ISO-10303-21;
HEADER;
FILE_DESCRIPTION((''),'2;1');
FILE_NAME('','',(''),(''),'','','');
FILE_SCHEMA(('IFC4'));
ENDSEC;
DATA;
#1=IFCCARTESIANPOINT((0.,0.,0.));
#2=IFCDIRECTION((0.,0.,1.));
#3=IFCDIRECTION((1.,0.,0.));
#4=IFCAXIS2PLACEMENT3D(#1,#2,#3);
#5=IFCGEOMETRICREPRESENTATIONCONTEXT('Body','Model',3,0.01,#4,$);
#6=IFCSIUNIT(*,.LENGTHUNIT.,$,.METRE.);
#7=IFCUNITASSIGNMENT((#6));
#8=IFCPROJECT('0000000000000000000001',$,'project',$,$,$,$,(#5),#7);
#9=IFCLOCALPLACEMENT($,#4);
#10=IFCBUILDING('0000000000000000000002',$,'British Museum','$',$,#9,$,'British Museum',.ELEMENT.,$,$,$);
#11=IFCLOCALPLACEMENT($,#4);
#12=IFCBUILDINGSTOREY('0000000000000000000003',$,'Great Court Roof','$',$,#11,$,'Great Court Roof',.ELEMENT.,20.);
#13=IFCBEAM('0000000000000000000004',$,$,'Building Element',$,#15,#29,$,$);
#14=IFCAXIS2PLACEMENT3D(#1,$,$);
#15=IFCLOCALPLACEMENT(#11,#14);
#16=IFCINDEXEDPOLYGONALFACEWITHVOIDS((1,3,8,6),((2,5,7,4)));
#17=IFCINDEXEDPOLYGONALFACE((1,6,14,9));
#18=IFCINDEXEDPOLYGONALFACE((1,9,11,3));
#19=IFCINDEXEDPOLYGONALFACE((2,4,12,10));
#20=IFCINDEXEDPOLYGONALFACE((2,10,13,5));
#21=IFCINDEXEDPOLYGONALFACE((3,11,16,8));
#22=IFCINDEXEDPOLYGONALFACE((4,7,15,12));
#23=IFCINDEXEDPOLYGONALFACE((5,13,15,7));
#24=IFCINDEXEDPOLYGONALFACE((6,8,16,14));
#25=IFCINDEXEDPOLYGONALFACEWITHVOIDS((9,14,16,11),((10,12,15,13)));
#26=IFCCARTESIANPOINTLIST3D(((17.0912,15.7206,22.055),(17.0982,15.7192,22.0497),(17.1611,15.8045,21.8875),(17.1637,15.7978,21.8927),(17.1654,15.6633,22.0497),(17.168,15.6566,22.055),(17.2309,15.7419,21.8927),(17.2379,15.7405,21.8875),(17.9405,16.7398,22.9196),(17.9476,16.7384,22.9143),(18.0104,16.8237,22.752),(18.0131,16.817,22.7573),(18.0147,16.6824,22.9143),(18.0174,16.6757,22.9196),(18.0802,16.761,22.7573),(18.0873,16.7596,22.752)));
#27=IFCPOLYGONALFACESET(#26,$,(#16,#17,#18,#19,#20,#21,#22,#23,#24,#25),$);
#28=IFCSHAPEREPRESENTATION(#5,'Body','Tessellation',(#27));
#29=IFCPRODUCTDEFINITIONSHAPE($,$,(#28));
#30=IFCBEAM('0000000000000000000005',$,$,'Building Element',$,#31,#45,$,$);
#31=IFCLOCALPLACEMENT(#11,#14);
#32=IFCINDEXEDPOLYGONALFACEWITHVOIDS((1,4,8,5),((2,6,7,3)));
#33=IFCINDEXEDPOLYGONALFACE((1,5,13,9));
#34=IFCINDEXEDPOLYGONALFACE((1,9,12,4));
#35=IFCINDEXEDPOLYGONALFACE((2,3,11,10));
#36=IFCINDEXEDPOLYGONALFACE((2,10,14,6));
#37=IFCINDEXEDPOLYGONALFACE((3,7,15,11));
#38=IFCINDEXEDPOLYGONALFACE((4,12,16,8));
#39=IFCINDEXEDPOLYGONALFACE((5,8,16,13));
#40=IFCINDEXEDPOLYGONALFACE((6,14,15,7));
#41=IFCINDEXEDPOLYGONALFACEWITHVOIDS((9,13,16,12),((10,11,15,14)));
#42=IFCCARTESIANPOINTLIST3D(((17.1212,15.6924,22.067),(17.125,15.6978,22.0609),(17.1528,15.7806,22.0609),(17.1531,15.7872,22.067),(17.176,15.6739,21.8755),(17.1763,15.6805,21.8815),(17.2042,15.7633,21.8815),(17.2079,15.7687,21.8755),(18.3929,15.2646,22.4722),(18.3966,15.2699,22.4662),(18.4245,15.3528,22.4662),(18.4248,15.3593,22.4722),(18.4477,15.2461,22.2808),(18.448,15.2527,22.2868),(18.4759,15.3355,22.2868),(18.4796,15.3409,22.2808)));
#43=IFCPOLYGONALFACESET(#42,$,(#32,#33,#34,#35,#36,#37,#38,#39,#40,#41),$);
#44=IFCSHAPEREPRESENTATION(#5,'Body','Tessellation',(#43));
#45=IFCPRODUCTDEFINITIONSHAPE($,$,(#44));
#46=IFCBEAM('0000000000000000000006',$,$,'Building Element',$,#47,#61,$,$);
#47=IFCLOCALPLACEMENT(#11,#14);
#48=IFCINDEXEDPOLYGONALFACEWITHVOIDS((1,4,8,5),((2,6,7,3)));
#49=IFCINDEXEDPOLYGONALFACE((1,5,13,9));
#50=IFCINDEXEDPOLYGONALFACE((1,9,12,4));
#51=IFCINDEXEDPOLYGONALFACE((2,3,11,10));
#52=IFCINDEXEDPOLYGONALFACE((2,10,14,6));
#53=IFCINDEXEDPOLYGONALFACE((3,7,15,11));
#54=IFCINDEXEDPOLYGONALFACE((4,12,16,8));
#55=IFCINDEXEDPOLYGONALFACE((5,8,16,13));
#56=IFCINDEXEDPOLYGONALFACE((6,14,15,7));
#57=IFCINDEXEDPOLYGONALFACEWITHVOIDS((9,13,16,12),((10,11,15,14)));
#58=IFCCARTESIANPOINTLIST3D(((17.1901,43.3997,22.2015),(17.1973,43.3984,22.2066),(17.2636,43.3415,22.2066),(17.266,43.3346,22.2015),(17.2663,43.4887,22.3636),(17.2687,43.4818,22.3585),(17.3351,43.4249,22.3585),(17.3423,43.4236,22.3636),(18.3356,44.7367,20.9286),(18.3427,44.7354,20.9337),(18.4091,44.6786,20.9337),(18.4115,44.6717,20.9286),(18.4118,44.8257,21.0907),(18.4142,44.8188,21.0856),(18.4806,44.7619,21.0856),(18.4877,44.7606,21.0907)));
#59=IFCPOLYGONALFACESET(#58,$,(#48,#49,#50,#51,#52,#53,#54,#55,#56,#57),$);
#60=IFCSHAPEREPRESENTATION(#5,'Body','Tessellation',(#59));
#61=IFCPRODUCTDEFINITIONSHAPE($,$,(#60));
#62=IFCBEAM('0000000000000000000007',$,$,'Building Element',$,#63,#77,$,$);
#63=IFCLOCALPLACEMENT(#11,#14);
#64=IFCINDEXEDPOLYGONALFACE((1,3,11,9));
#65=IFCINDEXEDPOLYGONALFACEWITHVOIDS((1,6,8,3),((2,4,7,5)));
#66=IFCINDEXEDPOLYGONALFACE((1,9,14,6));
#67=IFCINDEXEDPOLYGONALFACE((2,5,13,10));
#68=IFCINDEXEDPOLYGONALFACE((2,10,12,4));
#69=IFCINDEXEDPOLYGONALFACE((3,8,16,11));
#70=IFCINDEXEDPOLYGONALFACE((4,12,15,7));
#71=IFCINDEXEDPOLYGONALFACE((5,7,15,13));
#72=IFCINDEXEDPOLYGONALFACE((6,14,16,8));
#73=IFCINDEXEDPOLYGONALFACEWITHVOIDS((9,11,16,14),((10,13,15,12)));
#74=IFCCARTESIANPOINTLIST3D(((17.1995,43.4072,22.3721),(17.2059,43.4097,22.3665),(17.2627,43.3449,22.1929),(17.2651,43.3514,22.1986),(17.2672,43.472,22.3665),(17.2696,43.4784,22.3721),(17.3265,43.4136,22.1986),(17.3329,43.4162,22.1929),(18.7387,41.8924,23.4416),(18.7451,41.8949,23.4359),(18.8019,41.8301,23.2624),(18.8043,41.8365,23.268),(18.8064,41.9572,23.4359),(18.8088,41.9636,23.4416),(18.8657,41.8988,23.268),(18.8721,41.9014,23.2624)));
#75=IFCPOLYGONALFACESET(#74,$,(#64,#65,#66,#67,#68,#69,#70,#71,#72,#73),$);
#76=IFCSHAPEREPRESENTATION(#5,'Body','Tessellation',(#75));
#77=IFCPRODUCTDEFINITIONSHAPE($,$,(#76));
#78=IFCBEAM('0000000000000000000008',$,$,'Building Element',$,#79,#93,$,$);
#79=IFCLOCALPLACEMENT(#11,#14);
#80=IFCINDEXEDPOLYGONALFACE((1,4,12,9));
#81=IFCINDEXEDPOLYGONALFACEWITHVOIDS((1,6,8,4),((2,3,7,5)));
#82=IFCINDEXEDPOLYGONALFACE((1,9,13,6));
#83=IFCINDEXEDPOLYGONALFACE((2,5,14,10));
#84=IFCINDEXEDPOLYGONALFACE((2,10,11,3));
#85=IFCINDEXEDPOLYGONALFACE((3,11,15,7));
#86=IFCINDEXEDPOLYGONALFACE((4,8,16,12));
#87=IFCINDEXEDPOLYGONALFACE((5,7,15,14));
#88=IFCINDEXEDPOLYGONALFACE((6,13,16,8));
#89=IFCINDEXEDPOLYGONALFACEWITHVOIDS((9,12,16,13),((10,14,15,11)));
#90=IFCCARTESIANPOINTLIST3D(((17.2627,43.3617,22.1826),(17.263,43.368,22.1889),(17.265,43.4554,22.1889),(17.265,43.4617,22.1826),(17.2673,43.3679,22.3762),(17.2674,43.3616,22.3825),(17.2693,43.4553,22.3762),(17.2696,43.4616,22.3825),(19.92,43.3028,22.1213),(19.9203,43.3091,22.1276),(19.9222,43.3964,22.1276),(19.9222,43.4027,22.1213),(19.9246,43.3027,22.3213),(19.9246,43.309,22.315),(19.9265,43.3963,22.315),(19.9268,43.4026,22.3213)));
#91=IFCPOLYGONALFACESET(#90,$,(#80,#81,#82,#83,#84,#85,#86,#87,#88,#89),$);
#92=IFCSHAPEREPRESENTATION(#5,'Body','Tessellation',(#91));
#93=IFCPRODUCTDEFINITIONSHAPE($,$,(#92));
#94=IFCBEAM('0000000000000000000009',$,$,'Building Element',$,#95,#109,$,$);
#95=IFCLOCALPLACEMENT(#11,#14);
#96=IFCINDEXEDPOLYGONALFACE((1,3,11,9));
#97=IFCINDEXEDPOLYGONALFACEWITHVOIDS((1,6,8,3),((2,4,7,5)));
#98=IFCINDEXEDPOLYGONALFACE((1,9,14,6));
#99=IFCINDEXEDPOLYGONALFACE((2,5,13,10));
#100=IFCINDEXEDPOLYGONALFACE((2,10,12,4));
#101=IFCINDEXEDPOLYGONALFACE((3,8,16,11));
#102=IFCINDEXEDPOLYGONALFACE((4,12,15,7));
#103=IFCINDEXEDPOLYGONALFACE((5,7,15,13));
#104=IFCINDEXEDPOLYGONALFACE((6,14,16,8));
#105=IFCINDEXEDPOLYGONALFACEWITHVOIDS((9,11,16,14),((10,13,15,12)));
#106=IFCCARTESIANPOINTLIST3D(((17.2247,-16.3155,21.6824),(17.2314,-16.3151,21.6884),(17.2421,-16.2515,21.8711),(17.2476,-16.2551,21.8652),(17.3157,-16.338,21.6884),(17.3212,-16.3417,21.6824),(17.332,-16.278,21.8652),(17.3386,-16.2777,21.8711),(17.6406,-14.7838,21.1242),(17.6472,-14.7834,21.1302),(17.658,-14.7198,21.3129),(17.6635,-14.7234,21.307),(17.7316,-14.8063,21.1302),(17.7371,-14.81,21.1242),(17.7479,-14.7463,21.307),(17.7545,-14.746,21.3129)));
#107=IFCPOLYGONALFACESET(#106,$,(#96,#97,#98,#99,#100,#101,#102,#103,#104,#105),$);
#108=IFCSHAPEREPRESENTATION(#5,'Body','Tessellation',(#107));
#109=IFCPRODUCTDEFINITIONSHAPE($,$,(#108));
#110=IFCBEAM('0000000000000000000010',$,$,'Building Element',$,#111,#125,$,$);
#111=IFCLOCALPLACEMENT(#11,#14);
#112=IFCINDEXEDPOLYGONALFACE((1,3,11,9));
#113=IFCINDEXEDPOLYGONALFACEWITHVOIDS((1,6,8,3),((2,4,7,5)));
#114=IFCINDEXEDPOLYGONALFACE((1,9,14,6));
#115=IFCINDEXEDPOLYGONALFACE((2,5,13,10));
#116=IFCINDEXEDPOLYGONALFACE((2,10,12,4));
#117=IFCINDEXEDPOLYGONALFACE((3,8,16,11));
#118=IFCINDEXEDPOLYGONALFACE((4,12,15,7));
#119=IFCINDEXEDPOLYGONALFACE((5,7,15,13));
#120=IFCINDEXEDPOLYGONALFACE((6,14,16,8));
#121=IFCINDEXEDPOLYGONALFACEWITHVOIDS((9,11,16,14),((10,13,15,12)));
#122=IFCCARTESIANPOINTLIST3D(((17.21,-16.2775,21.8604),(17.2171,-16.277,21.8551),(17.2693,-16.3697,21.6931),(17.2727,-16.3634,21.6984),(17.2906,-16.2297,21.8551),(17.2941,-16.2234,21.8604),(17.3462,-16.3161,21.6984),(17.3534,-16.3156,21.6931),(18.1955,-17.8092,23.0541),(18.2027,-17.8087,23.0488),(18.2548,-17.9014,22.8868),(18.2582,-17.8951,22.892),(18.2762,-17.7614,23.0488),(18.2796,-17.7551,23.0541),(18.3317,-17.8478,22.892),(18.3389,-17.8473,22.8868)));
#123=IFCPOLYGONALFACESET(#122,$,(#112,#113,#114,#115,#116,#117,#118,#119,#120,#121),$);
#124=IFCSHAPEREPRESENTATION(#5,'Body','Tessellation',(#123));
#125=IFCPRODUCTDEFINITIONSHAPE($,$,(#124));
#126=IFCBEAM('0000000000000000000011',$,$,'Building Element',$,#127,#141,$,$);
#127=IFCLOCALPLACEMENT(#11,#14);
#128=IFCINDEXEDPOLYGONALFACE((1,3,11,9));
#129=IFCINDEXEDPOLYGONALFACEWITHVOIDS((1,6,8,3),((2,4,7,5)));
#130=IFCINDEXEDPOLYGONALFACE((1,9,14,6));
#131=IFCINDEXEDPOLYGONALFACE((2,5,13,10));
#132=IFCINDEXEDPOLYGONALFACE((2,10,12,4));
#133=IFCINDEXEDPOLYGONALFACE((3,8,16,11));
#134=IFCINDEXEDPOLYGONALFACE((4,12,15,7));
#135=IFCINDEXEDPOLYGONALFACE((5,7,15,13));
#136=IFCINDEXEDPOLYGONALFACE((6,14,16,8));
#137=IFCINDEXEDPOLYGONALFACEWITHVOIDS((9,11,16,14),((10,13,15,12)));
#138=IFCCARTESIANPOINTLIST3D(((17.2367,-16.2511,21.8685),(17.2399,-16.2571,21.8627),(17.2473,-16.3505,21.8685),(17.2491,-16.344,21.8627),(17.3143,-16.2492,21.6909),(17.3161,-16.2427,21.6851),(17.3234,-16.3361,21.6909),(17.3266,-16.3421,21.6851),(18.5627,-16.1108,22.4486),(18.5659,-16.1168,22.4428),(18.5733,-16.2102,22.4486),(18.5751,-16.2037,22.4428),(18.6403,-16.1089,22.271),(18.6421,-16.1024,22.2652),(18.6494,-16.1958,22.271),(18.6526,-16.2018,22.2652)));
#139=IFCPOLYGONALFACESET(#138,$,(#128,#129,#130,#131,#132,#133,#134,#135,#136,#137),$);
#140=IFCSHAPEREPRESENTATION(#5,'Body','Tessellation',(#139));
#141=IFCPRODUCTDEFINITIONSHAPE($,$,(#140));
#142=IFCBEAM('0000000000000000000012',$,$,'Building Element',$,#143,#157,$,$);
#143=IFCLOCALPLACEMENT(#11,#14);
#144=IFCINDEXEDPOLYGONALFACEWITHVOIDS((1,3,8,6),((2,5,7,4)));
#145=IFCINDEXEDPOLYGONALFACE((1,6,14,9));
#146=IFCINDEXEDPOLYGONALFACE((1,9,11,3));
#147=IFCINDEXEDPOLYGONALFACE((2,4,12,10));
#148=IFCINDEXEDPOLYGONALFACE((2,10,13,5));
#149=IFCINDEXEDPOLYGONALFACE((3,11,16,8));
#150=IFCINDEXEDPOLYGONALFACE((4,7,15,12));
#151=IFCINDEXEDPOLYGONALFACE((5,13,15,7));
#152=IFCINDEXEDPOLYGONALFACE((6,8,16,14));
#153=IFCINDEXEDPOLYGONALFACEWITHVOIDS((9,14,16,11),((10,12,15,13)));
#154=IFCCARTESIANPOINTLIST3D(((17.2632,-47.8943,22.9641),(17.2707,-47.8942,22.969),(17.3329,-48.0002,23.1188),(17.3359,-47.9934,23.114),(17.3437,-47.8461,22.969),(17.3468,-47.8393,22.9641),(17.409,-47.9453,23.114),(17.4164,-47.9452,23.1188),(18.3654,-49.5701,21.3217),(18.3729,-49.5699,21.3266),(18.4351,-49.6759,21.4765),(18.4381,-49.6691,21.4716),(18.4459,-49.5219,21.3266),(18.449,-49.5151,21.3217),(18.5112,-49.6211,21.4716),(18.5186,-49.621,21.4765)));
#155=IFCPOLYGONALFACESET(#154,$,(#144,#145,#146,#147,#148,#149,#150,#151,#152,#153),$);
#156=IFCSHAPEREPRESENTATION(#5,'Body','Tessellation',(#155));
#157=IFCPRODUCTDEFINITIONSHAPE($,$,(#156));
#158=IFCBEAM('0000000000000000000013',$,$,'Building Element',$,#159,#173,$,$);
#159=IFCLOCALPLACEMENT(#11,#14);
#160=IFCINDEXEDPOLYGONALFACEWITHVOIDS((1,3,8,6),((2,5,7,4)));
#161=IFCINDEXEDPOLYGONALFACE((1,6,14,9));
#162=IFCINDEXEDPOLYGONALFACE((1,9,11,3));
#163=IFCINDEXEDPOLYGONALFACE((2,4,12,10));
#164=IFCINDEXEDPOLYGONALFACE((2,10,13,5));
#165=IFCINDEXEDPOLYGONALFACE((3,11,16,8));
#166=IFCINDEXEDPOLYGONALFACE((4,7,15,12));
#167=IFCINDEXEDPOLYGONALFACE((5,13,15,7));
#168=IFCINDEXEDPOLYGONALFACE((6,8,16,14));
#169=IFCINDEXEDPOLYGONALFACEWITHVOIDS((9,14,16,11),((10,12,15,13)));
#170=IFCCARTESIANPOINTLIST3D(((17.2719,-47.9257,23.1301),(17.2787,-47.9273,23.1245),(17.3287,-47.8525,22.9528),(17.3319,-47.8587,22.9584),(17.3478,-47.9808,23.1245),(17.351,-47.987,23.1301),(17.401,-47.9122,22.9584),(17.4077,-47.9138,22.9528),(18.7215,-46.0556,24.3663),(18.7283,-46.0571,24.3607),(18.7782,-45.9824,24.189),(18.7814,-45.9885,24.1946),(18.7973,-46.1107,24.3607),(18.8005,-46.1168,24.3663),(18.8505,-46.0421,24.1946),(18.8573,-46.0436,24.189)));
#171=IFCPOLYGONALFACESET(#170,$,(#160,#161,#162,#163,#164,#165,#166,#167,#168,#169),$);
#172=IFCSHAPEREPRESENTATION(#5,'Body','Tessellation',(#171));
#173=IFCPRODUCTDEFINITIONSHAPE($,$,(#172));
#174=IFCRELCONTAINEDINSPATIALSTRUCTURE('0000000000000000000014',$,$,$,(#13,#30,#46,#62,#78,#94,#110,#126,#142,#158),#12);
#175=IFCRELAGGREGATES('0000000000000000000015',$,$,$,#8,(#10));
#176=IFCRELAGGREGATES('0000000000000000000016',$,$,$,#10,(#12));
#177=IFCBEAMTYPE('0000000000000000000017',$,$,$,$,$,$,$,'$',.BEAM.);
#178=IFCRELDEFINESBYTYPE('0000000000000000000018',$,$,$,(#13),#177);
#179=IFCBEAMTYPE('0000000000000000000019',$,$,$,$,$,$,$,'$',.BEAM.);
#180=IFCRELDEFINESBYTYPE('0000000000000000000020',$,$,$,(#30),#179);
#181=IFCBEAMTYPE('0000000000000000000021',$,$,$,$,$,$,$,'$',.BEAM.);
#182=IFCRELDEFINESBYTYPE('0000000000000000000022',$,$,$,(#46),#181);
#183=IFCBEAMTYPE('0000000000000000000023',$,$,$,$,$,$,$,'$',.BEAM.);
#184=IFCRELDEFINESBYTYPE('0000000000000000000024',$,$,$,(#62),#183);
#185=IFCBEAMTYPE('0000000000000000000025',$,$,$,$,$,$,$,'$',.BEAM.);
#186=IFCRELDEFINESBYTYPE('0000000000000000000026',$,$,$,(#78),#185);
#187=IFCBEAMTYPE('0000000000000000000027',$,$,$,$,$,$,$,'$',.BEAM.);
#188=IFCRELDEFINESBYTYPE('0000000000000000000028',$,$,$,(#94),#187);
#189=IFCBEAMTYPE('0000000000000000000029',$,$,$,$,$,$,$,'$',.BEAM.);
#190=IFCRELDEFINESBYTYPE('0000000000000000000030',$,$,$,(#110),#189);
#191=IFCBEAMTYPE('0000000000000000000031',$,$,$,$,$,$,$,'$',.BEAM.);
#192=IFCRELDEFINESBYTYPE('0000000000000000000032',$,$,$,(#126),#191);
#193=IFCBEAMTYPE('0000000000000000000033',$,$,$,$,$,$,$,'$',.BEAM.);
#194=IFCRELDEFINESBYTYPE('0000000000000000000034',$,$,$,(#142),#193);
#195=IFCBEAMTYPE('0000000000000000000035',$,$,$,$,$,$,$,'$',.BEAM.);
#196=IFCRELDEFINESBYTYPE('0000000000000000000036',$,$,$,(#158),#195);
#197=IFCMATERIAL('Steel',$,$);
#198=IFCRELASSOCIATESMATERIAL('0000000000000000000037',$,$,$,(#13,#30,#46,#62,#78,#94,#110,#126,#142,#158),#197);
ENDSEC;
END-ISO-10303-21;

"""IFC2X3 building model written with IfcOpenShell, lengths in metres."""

from ifc_helpers import new_model, si_unit, frame, origin_with_axes, origin_2d, place, context, project, spatial, hollow_rectangle, extrude, material, type_object, element, save


model = new_model("IFC2X3")

# Units and contexts
model_context = context("Model", 3, precision=0.01, world=origin_with_axes(), identifier="Body")
ifc_project = project(units=[si_unit("LENGTHUNIT", "METRE")], contexts=[model_context])

# Building, storey
building_placement = place(None, origin_with_axes())
building = spatial("IfcBuilding", under=ifc_project, at=building_placement, Name="British Museum", Description="$", LongName="British Museum", CompositionType="ELEMENT")
storey_placement = place(None, origin_with_axes())
storey = spatial("IfcBuildingStorey", under=building, at=storey_placement, Name="Great Court Roof", Description="$", LongName="Great Court Roof", CompositionType="ELEMENT", Elevation=20.0)

# Beams
ifc_material = material(Name="Steel")
beam_type_1 = type_object("IfcBeamType", ElementType="$", PredefinedType="BEAM")
beam_1_placement = place(None, origin_with_axes())
element("IfcBeam", 1, at=beam_1_placement, inside=storey, type_object=beam_type_1, material=ifc_material, Description="Building Element", context=model_context, shape_type="SweptSolid", body=[
    extrude(hollow_rectangle(XDim=0.1, YDim=0.2, WallThickness=0.0063, InnerFilletRadius=0.0, OuterFilletRadius=0.0, at=origin_2d()), frame((17.1646, 15.7306, 21.9712), z_axis=(0.536356, 0.643597, 0.54599), x_axis=(-0.768206, 0.640203, 0.0)), (0.0, 0.0, 1.0), 1.5835),
])
beam_type_2 = type_object("IfcBeamType", ElementType="$", PredefinedType="BEAM")
beam_2_placement = place(None, origin_with_axes())
element("IfcBeam", 2, at=beam_2_placement, inside=storey, type_object=beam_type_2, material=ifc_material, Description="Building Element", context=model_context, shape_type="SweptSolid", body=[
    extrude(hollow_rectangle(XDim=0.1, YDim=0.2, WallThickness=0.0063, InnerFilletRadius=0.0, OuterFilletRadius=0.0, at=origin_2d()), frame((17.1646, 15.7306, 21.9712), z_axis=(0.907317, -0.30525, 0.289135), x_axis=(0.318869, 0.947799, 0.0)), (0.0, 0.0, 1.0), 1.4016),
])
beam_type_3 = type_object("IfcBeamType", ElementType="$", PredefinedType="BEAM")
beam_3_placement = place(None, origin_with_axes())
element("IfcBeam", 3, at=beam_3_placement, inside=storey, type_object=beam_type_3, material=ifc_material, Description="Building Element", context=model_context, shape_type="SweptSolid", body=[
    extrude(hollow_rectangle(XDim=0.1, YDim=0.2, WallThickness=0.0063, InnerFilletRadius=0.0, OuterFilletRadius=0.0, at=origin_2d()), frame((17.2662, 43.4117, 22.2825), z_axis=(0.527257, 0.615413, -0.58589), x_axis=(-0.759403, 0.650621, 0.0)), (0.0, 0.0, 1.0), 2.1725),
])
beam_type_4 = type_object("IfcBeamType", ElementType="$", PredefinedType="BEAM")
beam_4_placement = place(None, origin_with_axes())
element("IfcBeam", 4, at=beam_4_placement, inside=storey, type_object=beam_type_4, material=ifc_material, Description="Building Element", context=model_context, shape_type="SweptSolid", body=[
    extrude(hollow_rectangle(XDim=0.1, YDim=0.2, WallThickness=0.0063, InnerFilletRadius=0.0, OuterFilletRadius=0.0, at=origin_2d()), frame((17.2662, 43.4117, 22.2825), z_axis=(0.638706, -0.628582, 0.443778), x_axis=(0.701435, 0.712733, 0.0)), (0.0, 0.0, 1.0), 2.4099),
])
beam_type_5 = type_object("IfcBeamType", ElementType="$", PredefinedType="BEAM")
beam_5_placement = place(None, origin_with_axes())
element("IfcBeam", 5, at=beam_5_placement, inside=storey, type_object=beam_type_5, material=ifc_material, Description="Building Element", context=model_context, shape_type="SweptSolid", body=[
    extrude(hollow_rectangle(XDim=0.1, YDim=0.2, WallThickness=0.0063, InnerFilletRadius=0.0, OuterFilletRadius=0.0, at=origin_2d()), frame((17.2662, 43.4117, 22.2825), z_axis=(0.999489, -0.022179, -0.023032), x_axis=(0.022185, 0.999754, 0.0)), (0.0, 0.0, 1.0), 2.6586),
])
beam_type_6 = type_object("IfcBeamType", ElementType="$", PredefinedType="BEAM")
beam_6_placement = place(None, origin_with_axes())
element("IfcBeam", 6, at=beam_6_placement, inside=storey, type_object=beam_type_6, material=ifc_material, Description="Building Element", context=model_context, shape_type="SweptSolid", body=[
    extrude(hollow_rectangle(XDim=0.1, YDim=0.2, WallThickness=0.0063, InnerFilletRadius=0.0, OuterFilletRadius=0.0, at=origin_2d()), frame((17.2817, -16.2966, 21.7768), z_axis=(0.247187, 0.910395, -0.331782), x_axis=(-0.96506, 0.262029, 0.0)), (0.0, 0.0, 1.0), 1.6824),
])
beam_type_7 = type_object("IfcBeamType", ElementType="$", PredefinedType="BEAM")
beam_7_placement = place(None, origin_with_axes())
element("IfcBeam", 7, at=beam_7_placement, inside=storey, type_object=beam_type_7, material=ifc_material, Description="Building Element", context=model_context, shape_type="SweptSolid", body=[
    extrude(hollow_rectangle(XDim=0.1, YDim=0.2, WallThickness=0.0063, InnerFilletRadius=0.0, OuterFilletRadius=0.0, at=origin_2d()), frame((17.2817, -16.2966, 21.7768), z_axis=(0.45257, -0.703361, 0.548145), x_axis=(0.840956, 0.541104, 0.0)), (0.0, 0.0, 1.0), 2.1776),
])
beam_type_8 = type_object("IfcBeamType", ElementType="$", PredefinedType="BEAM")
beam_8_placement = place(None, origin_with_axes())
element("IfcBeam", 8, at=beam_8_placement, inside=storey, type_object=beam_type_8, material=ifc_material, Description="Building Element", context=model_context, shape_type="SweptSolid", body=[
    extrude(hollow_rectangle(XDim=0.1, YDim=0.2, WallThickness=0.0063, InnerFilletRadius=0.0, OuterFilletRadius=0.0, at=origin_2d()), frame((17.2817, -16.2966, 21.7768), z_axis=(0.911876, 0.096474, 0.398968), x_axis=(-0.10521, 0.99445, 0.0)), (0.0, 0.0, 1.0), 1.4541),
])
beam_type_9 = type_object("IfcBeamType", ElementType="$", PredefinedType="BEAM")
beam_9_placement = place(None, origin_with_axes())
element("IfcBeam", 9, at=beam_9_placement, inside=storey, type_object=beam_type_9, material=ifc_material, Description="Building Element", context=model_context, shape_type="SweptSolid", body=[
    extrude(hollow_rectangle(XDim=0.1, YDim=0.2, WallThickness=0.0063, InnerFilletRadius=0.0, OuterFilletRadius=0.0, at=origin_2d()), frame((17.3398, -47.9198, 23.0415), z_axis=(0.425165, -0.646418, -0.633544), x_axis=(0.835482, 0.549517, 0.0)), (0.0, 0.0, 1.0), 2.5924),
])
beam_type_10 = type_object("IfcBeamType", ElementType="$", PredefinedType="BEAM")
beam_10_placement = place(None, origin_with_axes())
element("IfcBeam", 10, at=beam_10_placement, inside=storey, type_object=beam_type_10, material=ifc_material, Description="Building Element", context=model_context, shape_type="SweptSolid", body=[
    extrude(hollow_rectangle(XDim=0.1, YDim=0.2, WallThickness=0.0063, InnerFilletRadius=0.0, OuterFilletRadius=0.0, at=origin_2d()), frame((17.3398, -47.9198, 23.0415), z_axis=(0.542983, 0.700538, 0.463051), x_axis=(-0.790379, 0.612619, 0.0)), (0.0, 0.0, 1.0), 2.6696),
])

save(model, "model.ifc")
